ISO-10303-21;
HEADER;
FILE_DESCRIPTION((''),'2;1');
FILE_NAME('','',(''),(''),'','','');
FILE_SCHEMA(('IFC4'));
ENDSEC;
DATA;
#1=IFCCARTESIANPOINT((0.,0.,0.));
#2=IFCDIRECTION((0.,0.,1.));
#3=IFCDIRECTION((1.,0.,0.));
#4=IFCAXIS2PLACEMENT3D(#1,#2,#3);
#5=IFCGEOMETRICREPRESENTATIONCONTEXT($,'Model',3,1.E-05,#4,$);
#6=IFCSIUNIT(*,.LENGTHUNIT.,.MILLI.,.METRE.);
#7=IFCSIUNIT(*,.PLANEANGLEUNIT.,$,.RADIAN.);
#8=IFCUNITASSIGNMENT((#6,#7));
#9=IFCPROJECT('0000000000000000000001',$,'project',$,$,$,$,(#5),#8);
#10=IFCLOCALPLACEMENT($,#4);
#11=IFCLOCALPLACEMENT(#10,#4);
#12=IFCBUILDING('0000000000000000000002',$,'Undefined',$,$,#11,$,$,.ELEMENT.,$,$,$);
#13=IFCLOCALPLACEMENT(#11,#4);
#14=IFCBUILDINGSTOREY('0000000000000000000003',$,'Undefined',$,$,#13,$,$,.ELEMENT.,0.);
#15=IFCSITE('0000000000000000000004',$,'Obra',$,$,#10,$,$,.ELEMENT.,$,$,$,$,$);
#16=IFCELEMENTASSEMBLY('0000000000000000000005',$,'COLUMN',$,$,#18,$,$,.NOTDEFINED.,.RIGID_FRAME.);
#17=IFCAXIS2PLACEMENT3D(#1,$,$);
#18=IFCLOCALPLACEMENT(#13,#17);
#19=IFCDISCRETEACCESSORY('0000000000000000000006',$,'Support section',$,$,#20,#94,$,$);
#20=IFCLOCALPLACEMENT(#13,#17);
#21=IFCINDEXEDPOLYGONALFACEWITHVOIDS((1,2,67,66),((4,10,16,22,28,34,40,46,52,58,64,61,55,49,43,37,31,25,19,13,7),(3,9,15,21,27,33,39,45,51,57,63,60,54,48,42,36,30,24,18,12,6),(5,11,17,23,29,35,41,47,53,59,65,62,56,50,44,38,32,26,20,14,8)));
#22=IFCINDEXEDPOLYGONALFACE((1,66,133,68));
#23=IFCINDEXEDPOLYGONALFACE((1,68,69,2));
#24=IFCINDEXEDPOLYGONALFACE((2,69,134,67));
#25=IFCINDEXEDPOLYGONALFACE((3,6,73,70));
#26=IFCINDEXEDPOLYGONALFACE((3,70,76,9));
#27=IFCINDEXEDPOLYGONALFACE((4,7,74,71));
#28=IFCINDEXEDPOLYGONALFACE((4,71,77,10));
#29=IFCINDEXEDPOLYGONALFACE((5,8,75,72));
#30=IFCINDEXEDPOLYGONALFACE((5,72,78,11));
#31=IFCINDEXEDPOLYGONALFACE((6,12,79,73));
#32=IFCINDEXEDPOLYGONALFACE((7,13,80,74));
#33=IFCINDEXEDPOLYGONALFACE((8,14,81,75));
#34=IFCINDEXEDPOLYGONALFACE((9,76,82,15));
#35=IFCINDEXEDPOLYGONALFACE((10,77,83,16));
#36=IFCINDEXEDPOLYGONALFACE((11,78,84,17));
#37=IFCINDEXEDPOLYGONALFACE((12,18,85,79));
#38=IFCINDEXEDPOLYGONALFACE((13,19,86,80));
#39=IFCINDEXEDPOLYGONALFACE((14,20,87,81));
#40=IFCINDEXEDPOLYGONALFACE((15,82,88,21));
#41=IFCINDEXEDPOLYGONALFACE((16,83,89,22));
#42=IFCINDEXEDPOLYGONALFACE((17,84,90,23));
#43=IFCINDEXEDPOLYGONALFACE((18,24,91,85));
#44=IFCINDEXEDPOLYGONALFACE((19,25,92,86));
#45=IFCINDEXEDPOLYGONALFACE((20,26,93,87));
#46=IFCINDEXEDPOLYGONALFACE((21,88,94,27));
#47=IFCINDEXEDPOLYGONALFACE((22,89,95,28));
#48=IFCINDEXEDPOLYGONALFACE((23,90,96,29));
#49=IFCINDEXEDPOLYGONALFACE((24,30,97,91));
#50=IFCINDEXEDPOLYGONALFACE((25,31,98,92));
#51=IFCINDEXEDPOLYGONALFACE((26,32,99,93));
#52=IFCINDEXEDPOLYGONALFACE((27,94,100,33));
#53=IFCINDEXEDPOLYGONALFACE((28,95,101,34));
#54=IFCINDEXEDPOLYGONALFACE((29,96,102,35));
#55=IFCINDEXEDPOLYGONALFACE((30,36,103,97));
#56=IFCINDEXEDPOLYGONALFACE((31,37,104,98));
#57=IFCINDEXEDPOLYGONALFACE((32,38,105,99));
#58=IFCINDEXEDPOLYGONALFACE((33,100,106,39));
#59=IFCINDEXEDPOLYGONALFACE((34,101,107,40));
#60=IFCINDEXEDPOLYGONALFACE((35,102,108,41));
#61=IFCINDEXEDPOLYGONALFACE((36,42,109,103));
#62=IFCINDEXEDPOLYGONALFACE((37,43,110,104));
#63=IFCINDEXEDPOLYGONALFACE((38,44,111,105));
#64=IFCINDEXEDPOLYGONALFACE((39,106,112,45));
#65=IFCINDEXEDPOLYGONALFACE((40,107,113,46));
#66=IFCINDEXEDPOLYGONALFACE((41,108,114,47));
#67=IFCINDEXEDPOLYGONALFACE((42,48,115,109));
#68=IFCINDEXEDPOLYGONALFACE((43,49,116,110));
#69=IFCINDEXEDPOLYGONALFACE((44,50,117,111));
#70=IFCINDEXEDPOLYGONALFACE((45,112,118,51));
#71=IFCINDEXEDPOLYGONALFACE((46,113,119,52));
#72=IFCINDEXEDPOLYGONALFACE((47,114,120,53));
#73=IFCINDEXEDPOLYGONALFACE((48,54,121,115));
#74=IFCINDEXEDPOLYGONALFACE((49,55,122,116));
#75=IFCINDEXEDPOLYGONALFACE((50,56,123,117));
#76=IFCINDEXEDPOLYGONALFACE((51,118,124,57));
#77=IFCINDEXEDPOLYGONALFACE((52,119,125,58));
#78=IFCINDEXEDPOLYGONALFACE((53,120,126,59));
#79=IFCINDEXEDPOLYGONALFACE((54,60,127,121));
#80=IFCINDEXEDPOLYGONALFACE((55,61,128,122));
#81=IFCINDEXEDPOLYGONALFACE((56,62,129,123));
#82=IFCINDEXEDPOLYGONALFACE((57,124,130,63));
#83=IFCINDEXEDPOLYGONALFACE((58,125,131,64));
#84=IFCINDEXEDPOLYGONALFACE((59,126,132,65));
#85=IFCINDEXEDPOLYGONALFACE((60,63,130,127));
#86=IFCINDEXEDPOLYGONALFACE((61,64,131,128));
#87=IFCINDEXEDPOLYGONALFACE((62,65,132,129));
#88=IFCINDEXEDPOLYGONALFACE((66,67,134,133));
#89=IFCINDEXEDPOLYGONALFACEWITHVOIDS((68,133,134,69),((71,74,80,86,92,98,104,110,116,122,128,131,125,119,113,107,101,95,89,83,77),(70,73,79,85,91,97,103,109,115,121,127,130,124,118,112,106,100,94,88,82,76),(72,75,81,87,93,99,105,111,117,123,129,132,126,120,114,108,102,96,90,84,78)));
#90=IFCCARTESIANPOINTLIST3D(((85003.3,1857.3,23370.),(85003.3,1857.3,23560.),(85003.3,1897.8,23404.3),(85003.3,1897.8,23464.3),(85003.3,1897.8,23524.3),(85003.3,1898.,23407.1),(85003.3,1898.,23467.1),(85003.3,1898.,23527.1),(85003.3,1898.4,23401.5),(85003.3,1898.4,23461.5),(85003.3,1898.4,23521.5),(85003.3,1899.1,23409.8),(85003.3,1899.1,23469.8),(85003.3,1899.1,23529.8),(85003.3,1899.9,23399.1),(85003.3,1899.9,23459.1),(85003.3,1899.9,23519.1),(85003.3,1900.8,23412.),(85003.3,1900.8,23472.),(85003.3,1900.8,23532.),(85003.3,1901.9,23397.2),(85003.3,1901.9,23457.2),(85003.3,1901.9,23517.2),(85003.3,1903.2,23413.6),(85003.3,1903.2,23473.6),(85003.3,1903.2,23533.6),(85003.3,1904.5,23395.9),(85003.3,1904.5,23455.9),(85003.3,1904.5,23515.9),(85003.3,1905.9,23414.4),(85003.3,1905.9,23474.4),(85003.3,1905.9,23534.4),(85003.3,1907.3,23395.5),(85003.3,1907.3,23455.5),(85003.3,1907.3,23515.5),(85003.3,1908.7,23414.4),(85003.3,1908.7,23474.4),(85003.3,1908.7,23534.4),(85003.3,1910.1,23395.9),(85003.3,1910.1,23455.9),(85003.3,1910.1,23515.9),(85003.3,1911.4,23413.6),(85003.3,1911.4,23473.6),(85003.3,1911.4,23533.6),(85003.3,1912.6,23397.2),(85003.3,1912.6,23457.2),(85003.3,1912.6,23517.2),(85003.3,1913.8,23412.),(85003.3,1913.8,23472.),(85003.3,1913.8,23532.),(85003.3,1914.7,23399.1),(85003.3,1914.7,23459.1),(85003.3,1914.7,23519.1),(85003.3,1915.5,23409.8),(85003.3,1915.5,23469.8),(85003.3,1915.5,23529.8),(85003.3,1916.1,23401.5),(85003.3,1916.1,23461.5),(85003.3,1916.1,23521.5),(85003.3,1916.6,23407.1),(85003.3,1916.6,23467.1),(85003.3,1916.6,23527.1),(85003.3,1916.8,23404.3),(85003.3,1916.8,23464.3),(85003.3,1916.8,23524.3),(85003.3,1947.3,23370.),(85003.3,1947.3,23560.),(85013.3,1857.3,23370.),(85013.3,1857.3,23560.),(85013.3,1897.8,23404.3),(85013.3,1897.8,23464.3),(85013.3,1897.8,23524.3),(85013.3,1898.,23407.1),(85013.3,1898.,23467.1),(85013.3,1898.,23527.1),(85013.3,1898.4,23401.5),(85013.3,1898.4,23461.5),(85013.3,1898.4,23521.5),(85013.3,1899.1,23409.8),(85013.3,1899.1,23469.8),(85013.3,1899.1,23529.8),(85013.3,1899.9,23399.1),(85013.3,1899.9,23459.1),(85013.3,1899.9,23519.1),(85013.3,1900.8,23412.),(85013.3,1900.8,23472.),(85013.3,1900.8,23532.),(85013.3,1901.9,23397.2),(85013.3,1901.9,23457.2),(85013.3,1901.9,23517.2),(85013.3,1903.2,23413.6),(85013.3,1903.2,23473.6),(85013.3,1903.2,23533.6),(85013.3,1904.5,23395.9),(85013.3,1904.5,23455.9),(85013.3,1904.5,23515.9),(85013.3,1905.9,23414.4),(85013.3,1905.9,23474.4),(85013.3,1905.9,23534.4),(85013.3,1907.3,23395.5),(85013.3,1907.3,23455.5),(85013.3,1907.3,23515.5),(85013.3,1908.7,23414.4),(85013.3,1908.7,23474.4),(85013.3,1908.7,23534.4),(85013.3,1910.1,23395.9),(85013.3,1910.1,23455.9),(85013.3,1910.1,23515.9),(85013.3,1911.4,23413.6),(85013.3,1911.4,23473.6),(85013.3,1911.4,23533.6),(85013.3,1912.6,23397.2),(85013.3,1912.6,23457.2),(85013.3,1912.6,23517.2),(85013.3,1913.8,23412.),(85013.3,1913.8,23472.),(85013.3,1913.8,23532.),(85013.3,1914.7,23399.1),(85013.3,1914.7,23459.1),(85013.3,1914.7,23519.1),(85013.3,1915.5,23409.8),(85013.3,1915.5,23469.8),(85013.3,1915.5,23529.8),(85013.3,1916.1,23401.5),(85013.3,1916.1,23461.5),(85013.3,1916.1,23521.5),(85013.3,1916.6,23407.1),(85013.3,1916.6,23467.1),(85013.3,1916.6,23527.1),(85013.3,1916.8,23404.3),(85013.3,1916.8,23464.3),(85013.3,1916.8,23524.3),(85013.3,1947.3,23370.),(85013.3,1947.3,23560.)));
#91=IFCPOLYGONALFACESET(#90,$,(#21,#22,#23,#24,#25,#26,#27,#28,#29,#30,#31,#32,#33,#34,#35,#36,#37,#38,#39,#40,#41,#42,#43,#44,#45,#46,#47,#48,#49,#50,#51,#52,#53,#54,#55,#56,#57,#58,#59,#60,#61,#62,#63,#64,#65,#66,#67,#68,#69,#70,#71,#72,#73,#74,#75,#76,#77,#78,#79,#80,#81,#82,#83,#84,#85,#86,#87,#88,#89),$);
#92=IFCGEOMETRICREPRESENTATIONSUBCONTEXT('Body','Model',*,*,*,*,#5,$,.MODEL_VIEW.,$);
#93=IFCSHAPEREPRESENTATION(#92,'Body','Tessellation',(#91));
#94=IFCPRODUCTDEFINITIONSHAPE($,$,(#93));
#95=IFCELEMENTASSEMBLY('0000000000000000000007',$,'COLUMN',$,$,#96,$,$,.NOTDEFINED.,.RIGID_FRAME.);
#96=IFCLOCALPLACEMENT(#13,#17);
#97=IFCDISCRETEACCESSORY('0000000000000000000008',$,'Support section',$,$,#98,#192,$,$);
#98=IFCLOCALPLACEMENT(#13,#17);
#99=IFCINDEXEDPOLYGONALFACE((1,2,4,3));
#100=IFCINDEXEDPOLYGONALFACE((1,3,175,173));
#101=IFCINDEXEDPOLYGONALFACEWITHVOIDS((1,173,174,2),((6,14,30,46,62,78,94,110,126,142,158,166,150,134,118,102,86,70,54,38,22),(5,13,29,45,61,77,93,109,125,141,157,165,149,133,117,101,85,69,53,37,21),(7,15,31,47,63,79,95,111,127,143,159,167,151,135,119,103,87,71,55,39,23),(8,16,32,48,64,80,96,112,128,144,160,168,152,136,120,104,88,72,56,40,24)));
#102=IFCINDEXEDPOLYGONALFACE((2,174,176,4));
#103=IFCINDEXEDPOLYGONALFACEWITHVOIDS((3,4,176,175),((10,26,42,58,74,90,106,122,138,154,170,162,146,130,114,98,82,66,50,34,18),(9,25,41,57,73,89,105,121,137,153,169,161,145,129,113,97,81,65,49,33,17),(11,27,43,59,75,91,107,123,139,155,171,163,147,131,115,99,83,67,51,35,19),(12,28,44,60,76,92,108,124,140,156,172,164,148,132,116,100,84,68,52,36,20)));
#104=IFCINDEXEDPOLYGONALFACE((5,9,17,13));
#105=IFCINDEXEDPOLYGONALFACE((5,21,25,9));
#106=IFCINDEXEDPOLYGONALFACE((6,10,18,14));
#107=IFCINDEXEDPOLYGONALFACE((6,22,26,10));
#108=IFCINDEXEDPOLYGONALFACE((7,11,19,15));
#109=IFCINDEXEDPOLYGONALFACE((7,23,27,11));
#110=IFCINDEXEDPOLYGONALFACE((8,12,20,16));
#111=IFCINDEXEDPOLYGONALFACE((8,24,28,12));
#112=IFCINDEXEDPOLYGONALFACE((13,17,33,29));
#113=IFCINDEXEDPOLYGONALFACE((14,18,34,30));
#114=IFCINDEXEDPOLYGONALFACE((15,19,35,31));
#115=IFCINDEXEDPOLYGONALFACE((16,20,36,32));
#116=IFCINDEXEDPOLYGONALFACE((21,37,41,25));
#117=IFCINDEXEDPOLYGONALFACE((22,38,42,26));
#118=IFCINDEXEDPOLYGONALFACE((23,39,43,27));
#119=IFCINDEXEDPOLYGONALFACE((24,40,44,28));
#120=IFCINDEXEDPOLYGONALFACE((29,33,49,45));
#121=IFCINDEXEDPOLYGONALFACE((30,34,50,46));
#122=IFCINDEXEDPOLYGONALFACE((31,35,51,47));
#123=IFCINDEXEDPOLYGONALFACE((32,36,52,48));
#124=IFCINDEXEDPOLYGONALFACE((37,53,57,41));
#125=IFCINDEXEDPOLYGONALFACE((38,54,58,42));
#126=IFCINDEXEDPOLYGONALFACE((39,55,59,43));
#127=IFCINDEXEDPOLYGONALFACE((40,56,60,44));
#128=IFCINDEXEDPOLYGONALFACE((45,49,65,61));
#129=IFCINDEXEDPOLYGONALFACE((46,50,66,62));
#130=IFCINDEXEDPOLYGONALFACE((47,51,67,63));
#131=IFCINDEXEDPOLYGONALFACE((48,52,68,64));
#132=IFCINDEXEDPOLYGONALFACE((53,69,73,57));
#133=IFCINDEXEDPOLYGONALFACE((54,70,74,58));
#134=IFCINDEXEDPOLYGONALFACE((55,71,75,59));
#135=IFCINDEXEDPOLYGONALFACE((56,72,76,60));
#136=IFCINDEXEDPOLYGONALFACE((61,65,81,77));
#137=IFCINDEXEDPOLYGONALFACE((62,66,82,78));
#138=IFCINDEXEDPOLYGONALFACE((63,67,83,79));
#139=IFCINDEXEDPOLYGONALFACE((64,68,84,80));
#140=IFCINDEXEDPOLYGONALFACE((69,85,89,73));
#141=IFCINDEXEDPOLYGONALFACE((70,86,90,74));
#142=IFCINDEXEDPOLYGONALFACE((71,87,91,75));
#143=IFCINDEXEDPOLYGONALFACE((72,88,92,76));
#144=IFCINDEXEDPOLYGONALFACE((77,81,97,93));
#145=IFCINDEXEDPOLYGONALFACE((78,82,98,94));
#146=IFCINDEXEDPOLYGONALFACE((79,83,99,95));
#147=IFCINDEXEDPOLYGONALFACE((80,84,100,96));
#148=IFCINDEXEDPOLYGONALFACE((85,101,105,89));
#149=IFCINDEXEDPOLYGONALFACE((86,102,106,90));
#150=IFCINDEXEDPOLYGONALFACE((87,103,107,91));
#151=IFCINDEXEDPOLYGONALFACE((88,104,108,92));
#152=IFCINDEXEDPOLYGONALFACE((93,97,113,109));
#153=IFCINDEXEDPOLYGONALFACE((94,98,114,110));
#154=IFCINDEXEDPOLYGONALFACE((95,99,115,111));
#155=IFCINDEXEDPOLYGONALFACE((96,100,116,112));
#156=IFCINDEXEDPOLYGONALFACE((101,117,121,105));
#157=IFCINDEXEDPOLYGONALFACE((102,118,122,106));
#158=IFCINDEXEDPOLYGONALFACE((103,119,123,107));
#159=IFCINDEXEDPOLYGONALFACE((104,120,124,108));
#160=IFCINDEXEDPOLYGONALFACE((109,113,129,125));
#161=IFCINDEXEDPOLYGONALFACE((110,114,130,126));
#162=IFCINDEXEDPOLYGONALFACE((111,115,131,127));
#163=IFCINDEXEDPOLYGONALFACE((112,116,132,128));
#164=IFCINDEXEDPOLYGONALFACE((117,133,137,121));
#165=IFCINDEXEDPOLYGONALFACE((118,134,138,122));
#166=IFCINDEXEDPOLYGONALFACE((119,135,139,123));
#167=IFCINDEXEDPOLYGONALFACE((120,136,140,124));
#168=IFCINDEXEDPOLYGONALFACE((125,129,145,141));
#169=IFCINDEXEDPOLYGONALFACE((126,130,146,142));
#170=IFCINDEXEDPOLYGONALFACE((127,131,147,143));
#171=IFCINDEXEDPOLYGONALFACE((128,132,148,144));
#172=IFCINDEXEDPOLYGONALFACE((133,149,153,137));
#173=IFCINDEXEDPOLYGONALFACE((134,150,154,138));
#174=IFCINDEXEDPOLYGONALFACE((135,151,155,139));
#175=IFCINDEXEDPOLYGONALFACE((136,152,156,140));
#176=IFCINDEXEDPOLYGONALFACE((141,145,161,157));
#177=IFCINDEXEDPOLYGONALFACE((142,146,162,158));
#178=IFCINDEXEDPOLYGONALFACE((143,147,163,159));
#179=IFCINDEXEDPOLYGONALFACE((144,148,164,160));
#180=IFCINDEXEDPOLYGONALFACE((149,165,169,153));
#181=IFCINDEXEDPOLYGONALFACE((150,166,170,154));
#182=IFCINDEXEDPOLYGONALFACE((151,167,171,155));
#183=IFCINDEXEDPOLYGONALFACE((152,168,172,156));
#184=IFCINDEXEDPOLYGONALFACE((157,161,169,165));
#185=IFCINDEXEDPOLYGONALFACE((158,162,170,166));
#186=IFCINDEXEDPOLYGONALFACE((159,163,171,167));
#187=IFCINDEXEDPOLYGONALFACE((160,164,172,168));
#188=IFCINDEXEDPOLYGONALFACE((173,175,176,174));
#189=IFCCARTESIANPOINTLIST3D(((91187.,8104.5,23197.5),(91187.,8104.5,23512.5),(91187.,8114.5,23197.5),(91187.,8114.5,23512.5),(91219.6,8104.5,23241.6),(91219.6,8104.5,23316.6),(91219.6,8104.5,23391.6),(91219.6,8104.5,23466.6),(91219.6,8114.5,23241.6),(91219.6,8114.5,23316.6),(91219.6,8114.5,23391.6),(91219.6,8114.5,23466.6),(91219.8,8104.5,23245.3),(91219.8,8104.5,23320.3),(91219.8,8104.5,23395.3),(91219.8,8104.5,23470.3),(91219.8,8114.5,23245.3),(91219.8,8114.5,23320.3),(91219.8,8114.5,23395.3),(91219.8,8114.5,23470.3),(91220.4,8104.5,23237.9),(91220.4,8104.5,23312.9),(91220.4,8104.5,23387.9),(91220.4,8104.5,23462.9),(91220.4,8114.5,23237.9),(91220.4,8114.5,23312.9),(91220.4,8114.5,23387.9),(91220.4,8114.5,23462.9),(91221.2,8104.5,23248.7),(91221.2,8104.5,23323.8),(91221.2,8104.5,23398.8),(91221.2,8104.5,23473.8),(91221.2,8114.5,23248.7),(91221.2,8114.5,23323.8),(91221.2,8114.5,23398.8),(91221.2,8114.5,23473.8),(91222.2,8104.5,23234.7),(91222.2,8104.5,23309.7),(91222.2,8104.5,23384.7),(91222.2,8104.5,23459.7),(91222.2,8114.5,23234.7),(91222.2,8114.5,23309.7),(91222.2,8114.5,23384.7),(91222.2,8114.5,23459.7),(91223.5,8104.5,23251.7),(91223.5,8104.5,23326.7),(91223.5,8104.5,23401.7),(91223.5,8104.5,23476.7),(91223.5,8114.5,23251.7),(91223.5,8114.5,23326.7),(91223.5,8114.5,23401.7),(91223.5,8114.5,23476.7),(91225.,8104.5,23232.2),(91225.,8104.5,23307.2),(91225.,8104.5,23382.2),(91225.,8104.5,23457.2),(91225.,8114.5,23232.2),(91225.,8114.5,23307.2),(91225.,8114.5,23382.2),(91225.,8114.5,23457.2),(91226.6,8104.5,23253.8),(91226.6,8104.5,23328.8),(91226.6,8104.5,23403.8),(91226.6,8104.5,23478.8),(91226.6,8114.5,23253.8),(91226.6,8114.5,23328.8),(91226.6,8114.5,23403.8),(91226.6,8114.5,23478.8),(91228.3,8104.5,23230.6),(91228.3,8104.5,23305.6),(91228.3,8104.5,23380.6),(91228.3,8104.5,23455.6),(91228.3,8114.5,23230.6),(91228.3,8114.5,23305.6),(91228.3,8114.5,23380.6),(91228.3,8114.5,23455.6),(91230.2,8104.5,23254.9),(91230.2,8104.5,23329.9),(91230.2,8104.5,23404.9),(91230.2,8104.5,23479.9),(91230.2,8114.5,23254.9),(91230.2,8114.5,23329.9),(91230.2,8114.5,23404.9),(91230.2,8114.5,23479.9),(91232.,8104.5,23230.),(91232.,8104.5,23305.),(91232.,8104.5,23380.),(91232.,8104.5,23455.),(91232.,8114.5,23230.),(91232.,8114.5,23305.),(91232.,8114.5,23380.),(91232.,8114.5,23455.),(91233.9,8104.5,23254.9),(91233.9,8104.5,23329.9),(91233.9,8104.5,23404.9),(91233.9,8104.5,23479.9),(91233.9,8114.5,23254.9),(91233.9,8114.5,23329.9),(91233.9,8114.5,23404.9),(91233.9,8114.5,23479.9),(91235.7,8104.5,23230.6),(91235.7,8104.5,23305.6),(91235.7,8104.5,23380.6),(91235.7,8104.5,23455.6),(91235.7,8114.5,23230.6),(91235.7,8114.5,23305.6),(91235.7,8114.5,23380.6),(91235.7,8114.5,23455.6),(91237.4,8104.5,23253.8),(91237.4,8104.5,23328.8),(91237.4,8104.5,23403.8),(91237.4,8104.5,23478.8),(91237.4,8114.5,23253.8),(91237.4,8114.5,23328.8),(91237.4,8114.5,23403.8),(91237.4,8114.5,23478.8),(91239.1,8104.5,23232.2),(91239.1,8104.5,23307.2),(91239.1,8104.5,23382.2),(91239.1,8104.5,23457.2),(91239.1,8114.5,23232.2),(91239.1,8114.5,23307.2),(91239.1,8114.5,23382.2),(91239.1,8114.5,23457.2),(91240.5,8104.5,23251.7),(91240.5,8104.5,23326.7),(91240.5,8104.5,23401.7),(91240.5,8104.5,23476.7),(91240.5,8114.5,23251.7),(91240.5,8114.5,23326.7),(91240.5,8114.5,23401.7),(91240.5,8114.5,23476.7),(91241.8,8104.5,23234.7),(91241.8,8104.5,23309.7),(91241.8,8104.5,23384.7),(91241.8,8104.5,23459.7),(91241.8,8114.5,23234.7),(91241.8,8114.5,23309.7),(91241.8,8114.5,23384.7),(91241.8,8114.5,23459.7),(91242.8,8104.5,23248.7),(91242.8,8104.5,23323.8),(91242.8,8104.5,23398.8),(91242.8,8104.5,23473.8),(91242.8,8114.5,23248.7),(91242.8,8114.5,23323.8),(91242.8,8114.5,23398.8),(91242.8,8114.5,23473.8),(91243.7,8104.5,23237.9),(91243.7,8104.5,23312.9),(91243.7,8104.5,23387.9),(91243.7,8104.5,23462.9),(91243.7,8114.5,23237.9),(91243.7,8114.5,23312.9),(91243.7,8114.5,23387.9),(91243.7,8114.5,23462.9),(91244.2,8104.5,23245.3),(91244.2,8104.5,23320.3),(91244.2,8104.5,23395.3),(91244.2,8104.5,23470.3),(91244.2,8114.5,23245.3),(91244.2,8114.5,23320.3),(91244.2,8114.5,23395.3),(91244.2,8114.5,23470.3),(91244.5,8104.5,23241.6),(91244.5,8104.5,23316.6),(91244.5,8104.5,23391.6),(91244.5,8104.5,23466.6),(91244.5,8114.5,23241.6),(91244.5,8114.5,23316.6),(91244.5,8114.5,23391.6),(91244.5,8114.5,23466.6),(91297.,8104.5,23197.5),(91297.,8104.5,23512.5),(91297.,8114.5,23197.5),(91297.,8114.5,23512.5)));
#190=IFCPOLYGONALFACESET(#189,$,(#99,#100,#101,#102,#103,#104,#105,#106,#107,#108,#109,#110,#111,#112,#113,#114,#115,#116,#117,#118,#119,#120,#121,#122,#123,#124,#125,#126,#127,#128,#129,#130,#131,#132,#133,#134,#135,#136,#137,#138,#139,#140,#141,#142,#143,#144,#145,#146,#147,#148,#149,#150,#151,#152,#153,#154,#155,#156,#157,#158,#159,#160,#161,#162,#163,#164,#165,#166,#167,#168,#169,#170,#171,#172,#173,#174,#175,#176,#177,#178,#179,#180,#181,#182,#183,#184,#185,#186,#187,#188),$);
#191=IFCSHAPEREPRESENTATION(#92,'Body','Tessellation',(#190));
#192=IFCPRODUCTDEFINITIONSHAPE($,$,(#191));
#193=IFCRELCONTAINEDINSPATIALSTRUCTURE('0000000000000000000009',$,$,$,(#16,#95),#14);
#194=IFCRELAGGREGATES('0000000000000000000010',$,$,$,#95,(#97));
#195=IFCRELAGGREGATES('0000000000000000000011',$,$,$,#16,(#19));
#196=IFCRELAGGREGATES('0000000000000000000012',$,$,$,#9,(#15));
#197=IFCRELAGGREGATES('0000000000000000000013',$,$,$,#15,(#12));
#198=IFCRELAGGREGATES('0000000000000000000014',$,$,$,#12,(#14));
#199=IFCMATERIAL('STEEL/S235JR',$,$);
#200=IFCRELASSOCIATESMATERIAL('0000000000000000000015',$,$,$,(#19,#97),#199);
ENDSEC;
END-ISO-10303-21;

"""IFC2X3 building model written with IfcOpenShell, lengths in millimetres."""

from ifc_helpers import new_model, si_unit, frame, origin_with_axes, origin_2d_with_axis, place, context, subcontext, project, spatial, rectangle, circle, extrude, source, transform, mapped, material, element, aggregate, save


model = new_model("IFC2X3")

# Units and contexts
model_context = context("Model", 3, precision=1e-05, world=origin_with_axes())
body_context = subcontext(model_context, "Body", "Model", "MODEL_VIEW")
ifc_project = project(units=[si_unit("LENGTHUNIT", "METRE", prefix="MILLI"), si_unit("PLANEANGLEUNIT", "RADIAN")], contexts=[model_context])

# Site, building, storey
site_placement = place(None, origin_with_axes())
site = spatial("IfcSite", under=ifc_project, at=site_placement, Name="Obra", CompositionType="ELEMENT")
building_placement = place(site_placement, origin_with_axes())
building = spatial("IfcBuilding", under=site, at=building_placement, Name="Undefined", CompositionType="ELEMENT")
storey_placement = place(building_placement, origin_with_axes())
storey = spatial("IfcBuildingStorey", under=building, at=storey_placement, Name="Undefined", CompositionType="ELEMENT", Elevation=0.0)

# Element assemblies, discrete accessories, openings
assembly_1_placement = place(storey_placement, origin_with_axes())
assembly_1 = element("IfcElementAssembly", 1, at=assembly_1_placement, inside=storey, Name="COLUMN", AssemblyPlace="NOTDEFINED", PredefinedType="RIGID_FRAME")
ifc_material_1 = material(Name="STEEL/S235JR")
discrete_accessory_1_placement = place(assembly_1_placement, frame((85008.3, 1902.3, 23370.0), z_axis=(0.0, 0.0, 1.0), x_axis=(0.0, -1.0, 0.0)))
discrete_accessory_1 = element("IfcDiscreteAccessory", 2, at=discrete_accessory_1_placement, material=ifc_material_1, Name="Support section", context=body_context, shape_type="SweptSolid", body=[
    extrude(rectangle(XDim=10.0, YDim=90.0, at=origin_2d_with_axis()), frame((0.0, 0.0, 190.0), z_axis=(0.0, 0.0, -1.0), x_axis=(0.0, 1.0, 0.0)), (0.0, 0.0, 1.0), 190.0),
])
shared_shape_1 = source(origin_with_axes(), body_context, "Body", "SweptSolid", [
    extrude(circle(Radius=9.5, at=origin_2d_with_axis()), frame((0.0, -13.4, 0.0), z_axis=(0.0, 1.0, 0.0), x_axis=(1.0, 0.0, 0.0)), (0.0, 0.0, 1.0), 10.2),
])
opening_1_placement = place(assembly_1_placement, frame((85000.0, 1867.3, 23600.0), z_axis=(0.0, 1.0, 0.0), x_axis=(0.0, 0.0, -1.0)))
element("IfcOpeningElement", 3, at=opening_1_placement, cuts=discrete_accessory_1, ObjectType="Opening", context=body_context, shape_type="MappedRepresentation", body=[
    mapped(shared_shape_1, transform((75.0, 0.0, 40.0))),
    mapped(shared_shape_1, transform((135.0, 0.0, 40.0))),
    mapped(shared_shape_1, transform((195.0, 0.0, 40.0))),
])
assembly_2_placement = place(storey_placement, origin_with_axes())
assembly_2 = element("IfcElementAssembly", 4, at=assembly_2_placement, inside=storey, Name="COLUMN", AssemblyPlace="NOTDEFINED", PredefinedType="RIGID_FRAME")
discrete_accessory_2_placement = place(assembly_2_placement, frame((91242.0, 8109.5, 23197.5), z_axis=(0.0, 0.0, 1.0), x_axis=(1.0, 0.0, 0.0)))
discrete_accessory_2 = element("IfcDiscreteAccessory", 5, at=discrete_accessory_2_placement, material=ifc_material_1, Name="Support section", context=body_context, shape_type="SweptSolid", body=[
    extrude(rectangle(XDim=10.0, YDim=110.0, at=origin_2d_with_axis()), frame((0.0, 0.0, 315.0), z_axis=(0.0, 0.0, -1.0), x_axis=(0.0, 1.0, 0.0)), (0.0, 0.0, 1.0), 315.0),
])
shared_shape_2 = source(origin_with_axes(), body_context, "Body", "SweptSolid", [
    extrude(circle(Radius=12.5, at=origin_2d_with_axis()), frame((0.0, 5.7, 0.0), z_axis=(0.0, 1.0, 0.0), x_axis=(1.0, 0.0, 0.0)), (0.0, 0.0, 1.0), 10.2),
])
opening_2_placement = place(assembly_2_placement, frame((91277.0, 8120.2, 23575.0), z_axis=(-1.0, 0.0, 0.0), x_axis=(0.0, 0.0, -1.0)))
element("IfcOpeningElement", 6, at=opening_2_placement, cuts=discrete_accessory_2, ObjectType="Opening", context=body_context, shape_type="MappedRepresentation", body=[
    mapped(shared_shape_2, transform((107.5, 0.0, 45.0))),
    mapped(shared_shape_2, transform((182.5, 0.0, 45.0))),
    mapped(shared_shape_2, transform((257.5, 0.0, 45.0))),
    mapped(shared_shape_2, transform((332.5, 0.0, 45.0))),
])
aggregate(assembly_2, [discrete_accessory_2])

aggregate(assembly_1, [discrete_accessory_1])

save(model, "model.ifc")
